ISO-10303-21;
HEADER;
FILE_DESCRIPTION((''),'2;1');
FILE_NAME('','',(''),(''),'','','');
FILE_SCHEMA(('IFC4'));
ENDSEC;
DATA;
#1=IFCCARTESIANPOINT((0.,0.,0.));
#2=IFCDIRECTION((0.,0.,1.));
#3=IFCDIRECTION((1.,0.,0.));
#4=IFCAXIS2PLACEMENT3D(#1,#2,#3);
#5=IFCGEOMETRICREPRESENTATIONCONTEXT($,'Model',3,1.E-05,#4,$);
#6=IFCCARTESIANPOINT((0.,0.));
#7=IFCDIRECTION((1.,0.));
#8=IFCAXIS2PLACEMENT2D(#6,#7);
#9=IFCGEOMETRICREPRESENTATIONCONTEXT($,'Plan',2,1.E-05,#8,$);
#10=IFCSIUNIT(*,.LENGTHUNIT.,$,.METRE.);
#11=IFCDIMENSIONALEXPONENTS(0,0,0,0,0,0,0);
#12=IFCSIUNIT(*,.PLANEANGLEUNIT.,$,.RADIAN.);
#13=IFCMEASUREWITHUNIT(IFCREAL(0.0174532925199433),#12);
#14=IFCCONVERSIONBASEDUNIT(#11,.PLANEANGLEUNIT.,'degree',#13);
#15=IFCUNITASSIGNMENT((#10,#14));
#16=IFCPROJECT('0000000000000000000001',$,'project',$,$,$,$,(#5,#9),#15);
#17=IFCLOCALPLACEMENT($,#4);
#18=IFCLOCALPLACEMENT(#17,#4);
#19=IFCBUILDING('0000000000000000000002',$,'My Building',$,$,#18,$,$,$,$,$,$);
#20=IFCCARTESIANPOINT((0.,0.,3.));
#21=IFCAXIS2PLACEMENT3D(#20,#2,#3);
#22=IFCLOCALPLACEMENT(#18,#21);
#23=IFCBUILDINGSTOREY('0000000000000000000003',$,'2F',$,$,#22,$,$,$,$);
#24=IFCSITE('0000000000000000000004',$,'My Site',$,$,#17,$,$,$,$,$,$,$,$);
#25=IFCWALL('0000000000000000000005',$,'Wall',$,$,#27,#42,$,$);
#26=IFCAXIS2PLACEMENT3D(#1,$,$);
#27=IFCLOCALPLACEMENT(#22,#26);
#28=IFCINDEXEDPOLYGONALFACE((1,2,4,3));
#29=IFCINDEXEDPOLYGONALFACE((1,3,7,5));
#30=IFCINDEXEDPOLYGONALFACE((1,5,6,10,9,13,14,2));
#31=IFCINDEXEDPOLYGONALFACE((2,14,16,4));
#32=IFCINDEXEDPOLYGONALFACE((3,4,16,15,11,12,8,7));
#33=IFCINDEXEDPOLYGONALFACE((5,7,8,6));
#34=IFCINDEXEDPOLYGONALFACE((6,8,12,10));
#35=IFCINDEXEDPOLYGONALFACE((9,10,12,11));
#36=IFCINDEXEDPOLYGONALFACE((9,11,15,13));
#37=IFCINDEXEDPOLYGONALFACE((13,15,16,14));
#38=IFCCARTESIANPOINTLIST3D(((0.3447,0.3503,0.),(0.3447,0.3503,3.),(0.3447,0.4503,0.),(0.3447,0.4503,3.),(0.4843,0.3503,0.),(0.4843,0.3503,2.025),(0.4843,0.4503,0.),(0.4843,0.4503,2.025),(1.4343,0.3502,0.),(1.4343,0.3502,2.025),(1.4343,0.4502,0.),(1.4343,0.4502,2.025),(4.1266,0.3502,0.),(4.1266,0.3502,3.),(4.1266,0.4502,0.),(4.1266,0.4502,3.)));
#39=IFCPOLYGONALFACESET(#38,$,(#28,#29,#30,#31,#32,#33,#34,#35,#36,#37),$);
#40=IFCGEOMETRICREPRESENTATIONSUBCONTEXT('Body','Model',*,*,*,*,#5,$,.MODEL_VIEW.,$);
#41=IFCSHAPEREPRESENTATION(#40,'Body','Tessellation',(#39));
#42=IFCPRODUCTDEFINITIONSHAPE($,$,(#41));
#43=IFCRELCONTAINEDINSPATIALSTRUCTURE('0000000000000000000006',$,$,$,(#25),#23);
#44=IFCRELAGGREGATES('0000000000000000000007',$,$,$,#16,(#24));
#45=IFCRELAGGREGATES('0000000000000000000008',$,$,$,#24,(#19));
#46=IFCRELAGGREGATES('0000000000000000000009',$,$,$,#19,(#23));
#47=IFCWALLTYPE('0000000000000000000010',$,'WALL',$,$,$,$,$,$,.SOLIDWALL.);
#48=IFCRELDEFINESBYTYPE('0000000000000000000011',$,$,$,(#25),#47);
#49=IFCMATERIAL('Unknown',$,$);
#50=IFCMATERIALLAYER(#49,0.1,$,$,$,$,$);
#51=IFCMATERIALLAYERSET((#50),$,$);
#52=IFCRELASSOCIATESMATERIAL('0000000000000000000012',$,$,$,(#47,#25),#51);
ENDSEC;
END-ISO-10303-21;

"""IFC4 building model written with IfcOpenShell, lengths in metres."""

from ifc_helpers import new_model, entity, si_unit, converted_unit, frame, origin_with_axes, origin_2d_with_axis, place, context, subcontext, project, spatial, line, indexed_curve, outline, extrude, source, transform, mapped, material, layer, layer_set, layer_usage, type_object, element, save


model = new_model("IFC4")

# Units and contexts
model_context = context("Model", 3, precision=1e-05, world=origin_with_axes())
plan_context = context("Plan", 2, precision=1e-05, world=origin_2d_with_axis())
body_context_1 = subcontext(model_context, "Body", "Model", "MODEL_VIEW")
ifc_project = project(units=[si_unit("LENGTHUNIT", "METRE"), converted_unit("PLANEANGLEUNIT", "degree", entity("IfcReal", 0.0174532925199433), si_unit("PLANEANGLEUNIT", "RADIAN"), dimensions=[0, 0, 0, 0, 0, 0, 0])], contexts=[model_context, plan_context])

# Site, building, storey
site_placement = place(None, origin_with_axes())
site = spatial("IfcSite", under=ifc_project, at=site_placement, Name="My Site")
building_placement = place(site_placement, origin_with_axes())
building = spatial("IfcBuilding", under=site, at=building_placement, Name="My Building")
storey_placement = place(building_placement, frame((0.0, 0.0, 3.0), z_axis=(0.0, 0.0, 1.0), x_axis=(1.0, 0.0, 0.0)))
storey = spatial("IfcBuildingStorey", under=building, at=storey_placement, Name="2F")

# Shared definitions
ifc_material = material(Name="Unknown")

# Shared definitions
ifc_layer_1 = layer(ifc_material, 0.1)
ifc_layer_set_1 = layer_set([ifc_layer_1])
wall_type = type_object("IfcWallType", Name="WALL", PredefinedType="SOLIDWALL", material=ifc_layer_set_1)

# Wall, opening
ifc_layer_usage_1 = layer_usage(ifc_layer_set_1, "AXIS2", "POSITIVE", 0.0)
wall_1_placement = place(storey_placement, frame((4.1266, 0.4502, 0.0), z_axis=(0.0, 0.0, 1.0), x_axis=(-1.0, 0.000024, 0.0)))
wall_1 = element("IfcWall", 1, at=wall_1_placement, inside=storey, type_object=wall_type, material=ifc_layer_usage_1, Name="Wall", context=body_context_1, shape_type="SweptSolid", body=[
    extrude(outline(indexed_curve([(0.0, 0.0), (0.0, 0.1), (3.782, 0.1), (3.782, 0.0)], segments=[line(1, 2, 3, 4, 1)])), origin_with_axes(), (0.0, 0.0, 1.0), 3.0),
])
shared_shape_1 = source(origin_with_axes(), body_context_1, "Body", "SweptSolid", [
    extrude(outline(indexed_curve([(0.0, 0.0), (0.95, 0.0), (0.95, 2.025), (0.0, 2.025)], segments=[line(1, 2, 3, 4, 1)])), frame((-0.025, -0.6, 0.0), z_axis=(0.0, -1.0, 0.0), x_axis=(1.0, 0.0, 0.0)), (0.0, 0.0, -1.0), 1.2),
])
opening_1_placement = place(wall_1_placement, frame((2.7173, 0.0, 0.0), z_axis=(0.0, 0.0, 1.0), x_axis=(1.0, 0.0, 0.0)))
element("IfcOpeningElement", 2, at=opening_1_placement, cuts=wall_1, PredefinedType="OPENING", context=body_context_1, shape_type="MappedRepresentation", body=[
    mapped(shared_shape_1, transform((0.0, 0.0, 0.0), x_axis=(1.0, 0.0, 0.0), y_axis=(0.0, 1.0, 0.0), z_axis=(0.0, 0.0, 1.0), scale=1.0)),
])

save(model, "model.ifc")
